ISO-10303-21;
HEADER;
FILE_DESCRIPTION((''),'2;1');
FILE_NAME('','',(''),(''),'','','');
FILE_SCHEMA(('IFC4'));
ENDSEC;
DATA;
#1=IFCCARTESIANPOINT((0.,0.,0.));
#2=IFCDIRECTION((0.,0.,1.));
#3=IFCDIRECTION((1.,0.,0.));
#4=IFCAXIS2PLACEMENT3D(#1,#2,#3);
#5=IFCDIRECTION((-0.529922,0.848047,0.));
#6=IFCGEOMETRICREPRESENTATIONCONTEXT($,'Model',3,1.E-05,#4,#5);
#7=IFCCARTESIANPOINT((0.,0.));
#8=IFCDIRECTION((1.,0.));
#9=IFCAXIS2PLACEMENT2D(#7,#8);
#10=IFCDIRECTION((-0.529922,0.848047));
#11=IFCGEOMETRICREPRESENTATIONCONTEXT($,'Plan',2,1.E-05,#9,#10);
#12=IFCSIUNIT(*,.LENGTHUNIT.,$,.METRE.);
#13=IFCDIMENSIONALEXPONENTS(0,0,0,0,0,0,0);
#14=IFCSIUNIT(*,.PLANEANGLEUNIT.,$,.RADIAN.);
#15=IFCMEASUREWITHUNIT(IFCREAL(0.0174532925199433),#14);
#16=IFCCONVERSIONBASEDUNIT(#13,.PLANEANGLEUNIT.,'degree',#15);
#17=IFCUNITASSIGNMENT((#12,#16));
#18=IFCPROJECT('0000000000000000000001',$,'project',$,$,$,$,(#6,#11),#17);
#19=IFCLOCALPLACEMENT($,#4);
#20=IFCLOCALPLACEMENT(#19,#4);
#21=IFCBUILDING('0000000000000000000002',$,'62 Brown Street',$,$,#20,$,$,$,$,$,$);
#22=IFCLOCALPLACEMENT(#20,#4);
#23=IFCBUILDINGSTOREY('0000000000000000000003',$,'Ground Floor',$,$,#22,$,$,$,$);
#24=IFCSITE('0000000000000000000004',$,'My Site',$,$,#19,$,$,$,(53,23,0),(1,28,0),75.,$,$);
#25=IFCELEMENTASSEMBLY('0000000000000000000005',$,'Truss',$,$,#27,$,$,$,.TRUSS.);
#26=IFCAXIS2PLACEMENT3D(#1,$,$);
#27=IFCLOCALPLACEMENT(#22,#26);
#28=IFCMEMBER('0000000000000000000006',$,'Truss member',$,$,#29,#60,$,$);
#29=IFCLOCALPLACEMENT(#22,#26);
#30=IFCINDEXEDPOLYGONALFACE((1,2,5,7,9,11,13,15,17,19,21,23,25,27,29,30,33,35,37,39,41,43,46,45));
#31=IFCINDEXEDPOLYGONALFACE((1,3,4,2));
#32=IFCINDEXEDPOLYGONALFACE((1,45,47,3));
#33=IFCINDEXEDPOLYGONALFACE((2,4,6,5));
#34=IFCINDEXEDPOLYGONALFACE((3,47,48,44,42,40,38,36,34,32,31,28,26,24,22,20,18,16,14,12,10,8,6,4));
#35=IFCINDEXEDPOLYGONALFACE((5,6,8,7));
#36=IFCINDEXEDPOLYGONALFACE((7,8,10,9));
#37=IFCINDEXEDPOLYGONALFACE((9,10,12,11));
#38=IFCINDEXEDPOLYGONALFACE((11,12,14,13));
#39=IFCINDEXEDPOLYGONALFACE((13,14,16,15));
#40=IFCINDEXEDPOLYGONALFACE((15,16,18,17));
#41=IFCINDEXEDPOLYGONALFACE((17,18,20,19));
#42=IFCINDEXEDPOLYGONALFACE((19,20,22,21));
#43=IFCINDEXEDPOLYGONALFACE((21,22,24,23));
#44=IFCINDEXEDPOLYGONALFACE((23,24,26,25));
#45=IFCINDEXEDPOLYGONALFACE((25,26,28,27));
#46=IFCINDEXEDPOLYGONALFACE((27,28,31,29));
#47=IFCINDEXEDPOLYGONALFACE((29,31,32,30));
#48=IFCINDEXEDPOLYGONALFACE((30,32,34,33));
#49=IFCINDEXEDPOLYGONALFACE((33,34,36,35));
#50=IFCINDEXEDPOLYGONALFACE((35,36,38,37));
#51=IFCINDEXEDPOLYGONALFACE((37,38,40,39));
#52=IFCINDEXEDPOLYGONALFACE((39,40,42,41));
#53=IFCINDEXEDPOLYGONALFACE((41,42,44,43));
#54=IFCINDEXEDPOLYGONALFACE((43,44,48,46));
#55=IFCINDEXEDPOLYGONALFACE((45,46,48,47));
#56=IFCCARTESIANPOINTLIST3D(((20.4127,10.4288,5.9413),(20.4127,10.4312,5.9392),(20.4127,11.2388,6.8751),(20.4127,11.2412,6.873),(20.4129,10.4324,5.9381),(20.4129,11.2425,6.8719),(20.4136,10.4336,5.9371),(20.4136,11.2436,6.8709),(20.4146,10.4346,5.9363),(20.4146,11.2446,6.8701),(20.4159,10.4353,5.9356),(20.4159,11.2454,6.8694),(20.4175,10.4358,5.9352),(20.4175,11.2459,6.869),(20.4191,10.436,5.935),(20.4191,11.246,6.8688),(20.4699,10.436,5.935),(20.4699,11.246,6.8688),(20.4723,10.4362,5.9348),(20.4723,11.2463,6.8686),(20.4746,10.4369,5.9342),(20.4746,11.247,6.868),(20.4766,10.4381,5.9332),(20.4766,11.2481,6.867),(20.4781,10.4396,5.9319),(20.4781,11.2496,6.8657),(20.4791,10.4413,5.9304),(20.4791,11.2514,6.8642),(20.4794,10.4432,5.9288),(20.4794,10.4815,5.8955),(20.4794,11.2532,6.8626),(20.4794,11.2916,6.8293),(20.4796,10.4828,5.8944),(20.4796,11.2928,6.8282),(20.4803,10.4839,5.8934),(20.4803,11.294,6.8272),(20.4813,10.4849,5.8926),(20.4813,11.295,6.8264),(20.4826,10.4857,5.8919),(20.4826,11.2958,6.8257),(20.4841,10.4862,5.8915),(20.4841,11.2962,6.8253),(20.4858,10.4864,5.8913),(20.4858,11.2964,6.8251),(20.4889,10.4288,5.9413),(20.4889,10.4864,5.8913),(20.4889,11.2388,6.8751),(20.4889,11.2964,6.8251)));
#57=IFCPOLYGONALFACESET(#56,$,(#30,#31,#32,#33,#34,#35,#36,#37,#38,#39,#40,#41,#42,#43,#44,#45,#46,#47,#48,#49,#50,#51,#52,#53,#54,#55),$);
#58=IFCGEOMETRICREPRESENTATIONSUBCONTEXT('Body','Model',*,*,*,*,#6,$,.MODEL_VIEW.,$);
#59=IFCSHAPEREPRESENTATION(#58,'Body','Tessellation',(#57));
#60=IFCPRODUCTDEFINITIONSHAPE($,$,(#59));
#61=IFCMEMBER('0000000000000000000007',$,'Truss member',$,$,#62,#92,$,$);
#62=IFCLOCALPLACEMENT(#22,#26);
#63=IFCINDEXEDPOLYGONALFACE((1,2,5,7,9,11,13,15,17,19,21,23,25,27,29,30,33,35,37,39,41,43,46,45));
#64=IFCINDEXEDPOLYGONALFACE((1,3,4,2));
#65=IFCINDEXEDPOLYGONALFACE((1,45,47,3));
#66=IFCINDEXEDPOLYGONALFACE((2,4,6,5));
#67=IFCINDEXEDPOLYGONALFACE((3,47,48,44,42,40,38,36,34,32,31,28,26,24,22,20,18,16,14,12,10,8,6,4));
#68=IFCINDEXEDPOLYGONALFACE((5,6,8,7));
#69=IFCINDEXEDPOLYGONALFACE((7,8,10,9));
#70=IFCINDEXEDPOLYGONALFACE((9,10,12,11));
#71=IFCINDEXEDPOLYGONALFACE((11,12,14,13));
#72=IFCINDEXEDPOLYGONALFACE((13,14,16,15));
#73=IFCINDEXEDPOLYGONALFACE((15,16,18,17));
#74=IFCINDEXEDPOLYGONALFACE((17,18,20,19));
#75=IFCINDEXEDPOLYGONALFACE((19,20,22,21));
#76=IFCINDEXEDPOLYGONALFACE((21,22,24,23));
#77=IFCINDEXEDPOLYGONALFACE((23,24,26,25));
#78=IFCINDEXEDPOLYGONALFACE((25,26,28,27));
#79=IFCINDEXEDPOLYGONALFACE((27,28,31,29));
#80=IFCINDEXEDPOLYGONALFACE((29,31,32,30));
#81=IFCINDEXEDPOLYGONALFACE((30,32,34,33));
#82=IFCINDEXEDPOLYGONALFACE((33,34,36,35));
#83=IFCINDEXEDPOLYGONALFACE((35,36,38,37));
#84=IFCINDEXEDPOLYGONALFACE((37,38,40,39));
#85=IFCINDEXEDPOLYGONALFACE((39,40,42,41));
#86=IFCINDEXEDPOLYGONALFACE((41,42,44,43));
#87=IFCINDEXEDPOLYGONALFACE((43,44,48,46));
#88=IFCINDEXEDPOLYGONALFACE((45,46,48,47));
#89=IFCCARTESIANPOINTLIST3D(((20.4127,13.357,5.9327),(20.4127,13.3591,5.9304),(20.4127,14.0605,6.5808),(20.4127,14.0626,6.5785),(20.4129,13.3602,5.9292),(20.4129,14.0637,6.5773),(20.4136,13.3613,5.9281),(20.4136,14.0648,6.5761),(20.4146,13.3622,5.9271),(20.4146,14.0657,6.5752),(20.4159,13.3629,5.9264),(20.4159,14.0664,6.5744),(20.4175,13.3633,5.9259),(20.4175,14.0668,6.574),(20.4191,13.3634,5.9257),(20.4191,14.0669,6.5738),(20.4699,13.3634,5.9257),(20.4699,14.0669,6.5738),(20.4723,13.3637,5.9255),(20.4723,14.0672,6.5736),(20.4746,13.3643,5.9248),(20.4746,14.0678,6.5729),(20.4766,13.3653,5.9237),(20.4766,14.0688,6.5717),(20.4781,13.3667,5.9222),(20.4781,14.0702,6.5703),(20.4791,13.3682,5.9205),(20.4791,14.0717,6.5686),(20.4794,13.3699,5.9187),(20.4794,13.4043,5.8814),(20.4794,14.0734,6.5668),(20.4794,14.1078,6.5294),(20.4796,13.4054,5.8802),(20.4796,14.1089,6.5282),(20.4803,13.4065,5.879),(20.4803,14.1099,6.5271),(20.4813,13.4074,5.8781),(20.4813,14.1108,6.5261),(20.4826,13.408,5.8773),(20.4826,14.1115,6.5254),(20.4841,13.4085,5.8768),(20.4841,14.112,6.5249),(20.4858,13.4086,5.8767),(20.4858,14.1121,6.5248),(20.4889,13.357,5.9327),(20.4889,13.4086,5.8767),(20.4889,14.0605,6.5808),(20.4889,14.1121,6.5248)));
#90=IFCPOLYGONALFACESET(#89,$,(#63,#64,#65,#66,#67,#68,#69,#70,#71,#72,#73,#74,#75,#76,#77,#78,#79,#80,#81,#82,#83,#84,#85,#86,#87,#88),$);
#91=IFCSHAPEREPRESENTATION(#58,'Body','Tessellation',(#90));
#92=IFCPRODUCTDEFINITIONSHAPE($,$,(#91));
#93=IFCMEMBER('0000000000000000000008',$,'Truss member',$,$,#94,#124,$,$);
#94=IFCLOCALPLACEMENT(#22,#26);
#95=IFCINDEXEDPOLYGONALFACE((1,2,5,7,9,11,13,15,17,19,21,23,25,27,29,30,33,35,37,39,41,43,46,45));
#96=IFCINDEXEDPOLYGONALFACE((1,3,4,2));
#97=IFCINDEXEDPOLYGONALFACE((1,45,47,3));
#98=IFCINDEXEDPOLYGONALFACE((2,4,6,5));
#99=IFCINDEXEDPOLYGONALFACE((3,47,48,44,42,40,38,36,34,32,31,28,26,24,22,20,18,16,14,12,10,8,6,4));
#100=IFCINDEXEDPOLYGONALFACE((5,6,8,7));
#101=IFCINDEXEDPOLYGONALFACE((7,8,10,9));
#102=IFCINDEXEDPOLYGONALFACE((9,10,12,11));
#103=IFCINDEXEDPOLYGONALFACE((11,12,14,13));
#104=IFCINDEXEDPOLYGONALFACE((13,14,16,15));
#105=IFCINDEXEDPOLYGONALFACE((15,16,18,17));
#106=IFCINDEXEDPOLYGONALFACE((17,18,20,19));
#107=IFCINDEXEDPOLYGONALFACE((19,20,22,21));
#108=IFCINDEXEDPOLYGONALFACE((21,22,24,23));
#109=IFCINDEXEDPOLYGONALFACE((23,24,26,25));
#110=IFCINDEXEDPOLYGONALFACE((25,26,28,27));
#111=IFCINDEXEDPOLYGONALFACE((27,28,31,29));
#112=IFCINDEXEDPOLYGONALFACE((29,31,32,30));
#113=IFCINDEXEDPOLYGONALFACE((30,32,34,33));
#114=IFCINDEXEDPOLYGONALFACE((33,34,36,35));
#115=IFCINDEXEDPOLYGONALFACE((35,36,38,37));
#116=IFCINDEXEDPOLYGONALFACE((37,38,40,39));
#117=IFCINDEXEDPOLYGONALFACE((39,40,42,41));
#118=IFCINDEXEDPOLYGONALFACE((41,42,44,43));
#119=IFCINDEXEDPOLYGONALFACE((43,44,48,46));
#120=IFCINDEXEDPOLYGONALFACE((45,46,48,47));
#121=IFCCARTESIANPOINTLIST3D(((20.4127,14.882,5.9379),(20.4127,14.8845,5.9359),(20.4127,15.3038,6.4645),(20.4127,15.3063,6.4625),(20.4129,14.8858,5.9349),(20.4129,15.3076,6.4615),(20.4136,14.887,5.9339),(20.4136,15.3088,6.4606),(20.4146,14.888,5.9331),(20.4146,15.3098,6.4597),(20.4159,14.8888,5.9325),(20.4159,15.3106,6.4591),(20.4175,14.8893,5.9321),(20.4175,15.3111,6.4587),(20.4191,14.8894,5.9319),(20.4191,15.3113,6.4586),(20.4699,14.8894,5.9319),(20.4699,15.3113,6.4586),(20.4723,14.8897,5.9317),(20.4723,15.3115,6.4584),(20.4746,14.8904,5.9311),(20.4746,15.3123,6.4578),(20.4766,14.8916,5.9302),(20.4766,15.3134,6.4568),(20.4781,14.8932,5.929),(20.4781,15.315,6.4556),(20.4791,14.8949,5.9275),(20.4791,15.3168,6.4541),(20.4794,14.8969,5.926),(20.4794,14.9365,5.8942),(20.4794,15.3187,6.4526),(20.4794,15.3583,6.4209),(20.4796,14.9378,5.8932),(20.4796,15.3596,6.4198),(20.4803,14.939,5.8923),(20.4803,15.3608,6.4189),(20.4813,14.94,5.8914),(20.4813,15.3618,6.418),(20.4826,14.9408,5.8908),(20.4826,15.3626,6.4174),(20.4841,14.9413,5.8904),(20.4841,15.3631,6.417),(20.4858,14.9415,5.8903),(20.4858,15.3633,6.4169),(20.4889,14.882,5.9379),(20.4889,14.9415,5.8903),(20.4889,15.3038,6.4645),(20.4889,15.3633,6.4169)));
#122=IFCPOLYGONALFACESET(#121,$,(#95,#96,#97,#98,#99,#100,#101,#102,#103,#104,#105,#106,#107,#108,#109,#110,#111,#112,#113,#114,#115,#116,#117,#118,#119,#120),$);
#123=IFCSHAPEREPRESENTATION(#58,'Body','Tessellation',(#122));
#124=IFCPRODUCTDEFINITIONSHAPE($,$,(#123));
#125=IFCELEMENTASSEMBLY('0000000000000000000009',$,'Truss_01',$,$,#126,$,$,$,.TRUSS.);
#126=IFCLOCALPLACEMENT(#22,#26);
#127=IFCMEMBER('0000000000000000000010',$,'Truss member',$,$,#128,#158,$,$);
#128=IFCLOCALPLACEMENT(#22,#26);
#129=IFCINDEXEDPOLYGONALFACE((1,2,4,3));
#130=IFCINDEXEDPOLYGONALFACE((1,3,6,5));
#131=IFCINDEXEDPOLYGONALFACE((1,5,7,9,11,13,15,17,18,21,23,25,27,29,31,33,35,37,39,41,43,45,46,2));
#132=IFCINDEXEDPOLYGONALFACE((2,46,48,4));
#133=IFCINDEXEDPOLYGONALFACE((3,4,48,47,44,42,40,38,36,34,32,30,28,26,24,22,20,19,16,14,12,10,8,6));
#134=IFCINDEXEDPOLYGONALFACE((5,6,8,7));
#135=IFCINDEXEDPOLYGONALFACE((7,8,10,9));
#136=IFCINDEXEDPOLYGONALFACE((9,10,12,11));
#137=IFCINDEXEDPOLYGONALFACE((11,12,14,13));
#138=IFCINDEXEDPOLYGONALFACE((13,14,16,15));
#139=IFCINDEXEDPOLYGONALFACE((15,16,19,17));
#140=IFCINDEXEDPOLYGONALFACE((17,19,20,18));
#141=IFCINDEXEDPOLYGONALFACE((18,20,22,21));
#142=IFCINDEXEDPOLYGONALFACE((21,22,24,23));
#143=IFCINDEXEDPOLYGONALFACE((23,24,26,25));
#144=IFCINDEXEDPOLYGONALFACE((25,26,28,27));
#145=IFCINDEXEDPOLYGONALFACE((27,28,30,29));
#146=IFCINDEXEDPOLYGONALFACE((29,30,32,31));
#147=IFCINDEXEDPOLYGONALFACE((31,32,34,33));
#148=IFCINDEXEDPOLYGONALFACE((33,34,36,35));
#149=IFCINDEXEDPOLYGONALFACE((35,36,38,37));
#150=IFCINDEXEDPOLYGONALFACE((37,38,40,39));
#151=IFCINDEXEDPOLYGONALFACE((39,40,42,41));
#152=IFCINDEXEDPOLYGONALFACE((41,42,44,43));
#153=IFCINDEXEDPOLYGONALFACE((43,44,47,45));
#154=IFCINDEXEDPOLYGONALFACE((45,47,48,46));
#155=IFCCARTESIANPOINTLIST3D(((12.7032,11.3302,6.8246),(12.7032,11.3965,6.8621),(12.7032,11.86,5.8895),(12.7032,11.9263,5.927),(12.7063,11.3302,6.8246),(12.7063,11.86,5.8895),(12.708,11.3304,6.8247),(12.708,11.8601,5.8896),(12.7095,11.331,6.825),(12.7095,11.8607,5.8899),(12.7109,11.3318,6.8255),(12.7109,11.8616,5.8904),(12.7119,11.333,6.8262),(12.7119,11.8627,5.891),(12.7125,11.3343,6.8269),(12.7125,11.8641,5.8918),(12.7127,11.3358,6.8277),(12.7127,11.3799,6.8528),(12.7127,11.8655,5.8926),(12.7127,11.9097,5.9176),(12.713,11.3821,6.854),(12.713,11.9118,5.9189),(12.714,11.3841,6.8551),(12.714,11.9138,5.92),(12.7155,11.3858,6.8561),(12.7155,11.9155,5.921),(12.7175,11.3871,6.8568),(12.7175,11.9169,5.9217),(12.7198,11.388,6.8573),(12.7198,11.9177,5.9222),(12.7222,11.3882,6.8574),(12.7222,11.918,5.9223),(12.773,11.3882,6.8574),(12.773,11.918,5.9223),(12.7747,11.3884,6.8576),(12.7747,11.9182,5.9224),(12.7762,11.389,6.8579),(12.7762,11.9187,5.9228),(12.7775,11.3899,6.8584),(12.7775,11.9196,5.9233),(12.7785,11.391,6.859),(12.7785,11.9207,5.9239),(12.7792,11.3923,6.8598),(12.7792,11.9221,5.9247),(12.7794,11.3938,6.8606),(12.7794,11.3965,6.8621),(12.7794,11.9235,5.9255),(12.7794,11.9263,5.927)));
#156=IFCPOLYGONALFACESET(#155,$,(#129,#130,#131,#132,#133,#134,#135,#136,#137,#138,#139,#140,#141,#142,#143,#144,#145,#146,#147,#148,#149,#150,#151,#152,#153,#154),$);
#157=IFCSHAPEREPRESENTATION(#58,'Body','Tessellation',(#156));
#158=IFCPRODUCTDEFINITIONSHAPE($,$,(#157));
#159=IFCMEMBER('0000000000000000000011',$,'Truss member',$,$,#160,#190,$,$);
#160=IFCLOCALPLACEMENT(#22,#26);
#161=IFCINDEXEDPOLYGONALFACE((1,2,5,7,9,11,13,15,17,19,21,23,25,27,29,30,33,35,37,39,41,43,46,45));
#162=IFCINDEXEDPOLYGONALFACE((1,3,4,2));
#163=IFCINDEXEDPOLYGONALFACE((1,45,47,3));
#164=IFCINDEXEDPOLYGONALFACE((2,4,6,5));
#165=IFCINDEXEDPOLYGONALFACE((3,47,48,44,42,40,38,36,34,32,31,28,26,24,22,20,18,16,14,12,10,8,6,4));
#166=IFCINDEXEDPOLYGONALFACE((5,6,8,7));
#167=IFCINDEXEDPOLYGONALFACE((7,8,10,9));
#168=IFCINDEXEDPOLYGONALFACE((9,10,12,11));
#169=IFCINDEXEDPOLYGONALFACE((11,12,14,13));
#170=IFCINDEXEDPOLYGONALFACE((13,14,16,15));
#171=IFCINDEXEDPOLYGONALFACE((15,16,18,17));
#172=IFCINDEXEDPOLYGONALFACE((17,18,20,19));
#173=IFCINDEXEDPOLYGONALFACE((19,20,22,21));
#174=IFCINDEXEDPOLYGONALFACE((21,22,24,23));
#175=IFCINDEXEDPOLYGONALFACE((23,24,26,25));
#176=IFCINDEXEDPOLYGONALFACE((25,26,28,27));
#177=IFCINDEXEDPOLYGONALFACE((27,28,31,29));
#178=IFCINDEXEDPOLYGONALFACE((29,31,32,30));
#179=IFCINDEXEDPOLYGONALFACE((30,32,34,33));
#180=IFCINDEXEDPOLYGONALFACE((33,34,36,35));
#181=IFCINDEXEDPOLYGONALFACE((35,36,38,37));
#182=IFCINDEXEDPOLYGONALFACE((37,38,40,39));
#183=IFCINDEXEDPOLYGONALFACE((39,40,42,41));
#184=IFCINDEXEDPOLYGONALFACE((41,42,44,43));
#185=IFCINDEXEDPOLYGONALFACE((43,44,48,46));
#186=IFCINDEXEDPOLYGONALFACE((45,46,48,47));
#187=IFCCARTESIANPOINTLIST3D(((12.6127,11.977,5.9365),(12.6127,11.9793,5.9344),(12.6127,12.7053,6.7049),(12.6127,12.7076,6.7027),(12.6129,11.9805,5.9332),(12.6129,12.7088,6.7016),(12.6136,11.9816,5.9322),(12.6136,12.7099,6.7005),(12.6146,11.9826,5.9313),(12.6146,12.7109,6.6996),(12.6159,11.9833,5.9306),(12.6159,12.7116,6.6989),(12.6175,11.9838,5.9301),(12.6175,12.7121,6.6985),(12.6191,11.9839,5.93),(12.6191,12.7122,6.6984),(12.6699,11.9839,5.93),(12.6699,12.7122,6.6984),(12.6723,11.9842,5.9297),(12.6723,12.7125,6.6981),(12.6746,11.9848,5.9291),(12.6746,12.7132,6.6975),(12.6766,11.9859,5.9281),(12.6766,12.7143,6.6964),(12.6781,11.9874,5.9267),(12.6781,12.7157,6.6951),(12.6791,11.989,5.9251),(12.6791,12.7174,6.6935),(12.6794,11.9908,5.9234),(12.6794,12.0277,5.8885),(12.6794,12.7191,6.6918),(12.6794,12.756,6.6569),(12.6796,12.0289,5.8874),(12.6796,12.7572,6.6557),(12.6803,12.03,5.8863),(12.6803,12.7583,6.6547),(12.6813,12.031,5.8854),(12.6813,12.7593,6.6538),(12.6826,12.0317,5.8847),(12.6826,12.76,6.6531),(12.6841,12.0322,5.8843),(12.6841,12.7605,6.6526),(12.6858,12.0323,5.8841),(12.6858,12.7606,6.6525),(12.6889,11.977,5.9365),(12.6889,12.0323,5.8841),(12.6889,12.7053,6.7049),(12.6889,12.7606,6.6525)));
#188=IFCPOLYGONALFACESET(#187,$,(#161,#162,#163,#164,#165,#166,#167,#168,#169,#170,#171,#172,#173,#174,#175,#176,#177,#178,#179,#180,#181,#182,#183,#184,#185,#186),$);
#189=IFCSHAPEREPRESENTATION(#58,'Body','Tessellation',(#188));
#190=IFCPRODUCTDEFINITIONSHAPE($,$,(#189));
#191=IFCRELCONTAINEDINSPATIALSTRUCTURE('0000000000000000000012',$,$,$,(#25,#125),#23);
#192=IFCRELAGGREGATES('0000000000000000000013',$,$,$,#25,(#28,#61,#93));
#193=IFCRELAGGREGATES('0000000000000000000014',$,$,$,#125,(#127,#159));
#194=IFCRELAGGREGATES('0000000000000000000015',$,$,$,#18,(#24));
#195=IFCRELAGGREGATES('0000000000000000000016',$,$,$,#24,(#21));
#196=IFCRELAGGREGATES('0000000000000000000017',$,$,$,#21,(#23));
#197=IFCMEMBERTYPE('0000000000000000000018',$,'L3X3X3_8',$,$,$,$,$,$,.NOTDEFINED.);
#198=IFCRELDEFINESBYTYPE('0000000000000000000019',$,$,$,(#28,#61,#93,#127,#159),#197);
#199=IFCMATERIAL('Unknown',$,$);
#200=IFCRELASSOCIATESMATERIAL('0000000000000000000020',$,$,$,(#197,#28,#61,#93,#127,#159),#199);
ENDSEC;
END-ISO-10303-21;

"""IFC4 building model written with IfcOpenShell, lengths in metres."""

from ifc_helpers import new_model, entity, si_unit, converted_unit, direction, frame, origin_with_axes, origin_2d_with_axis, place, context, subcontext, project, spatial, l_section, extrude, material, material_profile, profile_set, profile_usage, type_object, element, aggregate, save


model = new_model("IFC4")

# Units and contexts
model_context = context("Model", 3, precision=1e-05, world=origin_with_axes(), true_north=direction((-0.529922, 0.848047, 0.0)))
plan_context = context("Plan", 2, precision=1e-05, world=origin_2d_with_axis(), true_north=direction((-0.529922, 0.848047)))
body_context = subcontext(model_context, "Body", "Model", "MODEL_VIEW")
ifc_project = project(units=[si_unit("LENGTHUNIT", "METRE"), converted_unit("PLANEANGLEUNIT", "degree", entity("IfcReal", 0.0174532925199433), si_unit("PLANEANGLEUNIT", "RADIAN"), dimensions=[0, 0, 0, 0, 0, 0, 0])], contexts=[model_context, plan_context])

# Site, building, storey
site_placement = place(None, origin_with_axes())
site = spatial("IfcSite", under=ifc_project, at=site_placement, Name="My Site", RefLatitude=(53, 23, 0), RefLongitude=(1, 28, 0), RefElevation=75.0)
building_placement = place(site_placement, origin_with_axes())
building = spatial("IfcBuilding", under=site, at=building_placement, Name="62 Brown Street")
storey_placement = place(building_placement, origin_with_axes())
storey = spatial("IfcBuildingStorey", under=building, at=storey_placement, Name="Ground Floor")

# Element assemblies, members
assembly_1_placement = place(storey_placement, frame((20.5032, 10.4288, 6.9738), z_axis=(0.0, 0.0, 1.0), x_axis=(1.0, 0.0, 0.0)))
assembly_1 = element("IfcElementAssembly", 1, at=assembly_1_placement, inside=storey, Name="Truss", PredefinedType="TRUSS")
ifc_material_1 = material(Name="Unknown")
ifc_material_profile_1 = material_profile(ifc_material_1, l_section(Depth=0.0762, Width=0.0762, Thickness=0.0095, FilletRadius=0.0095, EdgeRadius=0.0064))
ifc_profile_set_1 = profile_set([ifc_material_profile_1])
ifc_profile_usage_1 = profile_usage(ifc_profile_set_1, cardinal=5)
member_type_1 = type_object("IfcMemberType", Name="L3X3X3_8", PredefinedType="NOTDEFINED", material=ifc_profile_set_1)
member_1_placement = place(assembly_1_placement, frame((-0.0524, 0.8388, -0.1236), z_axis=(0.000001, -0.655276, -0.755389), x_axis=(-1.0, -0.000001, 0.0)))
member_1 = element("IfcMember", 2, at=member_1_placement, type_object=member_type_1, material=ifc_profile_usage_1, Name="Truss member", context=body_context, shape_type="SweptSolid", body=[
    extrude(l_section(Depth=0.0762, Width=0.0762, Thickness=0.0095, FilletRadius=0.0095, EdgeRadius=0.0064), origin_with_axes(), (0.0, 0.0, 1.0), 1.2362),
])
ifc_profile_usage_2 = profile_usage(ifc_profile_set_1, cardinal=5)
member_2_placement = place(assembly_1_placement, frame((-0.0524, 3.6575, -0.421), z_axis=(0.000001, -0.735484, -0.677542), x_axis=(-1.0, -0.000001, 0.0)))
member_2 = element("IfcMember", 3, at=member_2_placement, type_object=member_type_1, material=ifc_profile_usage_2, Name="Truss member", context=body_context, shape_type="SweptSolid", body=[
    extrude(l_section(Depth=0.0762, Width=0.0762, Thickness=0.0095, FilletRadius=0.0095, EdgeRadius=0.0064), origin_with_axes(), (0.0, 0.0, 1.0), 0.9565),
])
ifc_profile_usage_3 = profile_usage(ifc_profile_set_1, cardinal=5)
member_3_placement = place(assembly_1_placement, frame((-0.0524, 4.9048, -0.5331), z_axis=(0.000001, -0.625169, -0.780489), x_axis=(-1.0, -0.000001, 0.0)))
member_3 = element("IfcMember", 4, at=member_3_placement, type_object=member_type_1, material=ifc_profile_usage_3, Name="Truss member", context=body_context, shape_type="SweptSolid", body=[
    extrude(l_section(Depth=0.0762, Width=0.0762, Thickness=0.0095, FilletRadius=0.0095, EdgeRadius=0.0064), origin_with_axes(), (0.0, 0.0, 1.0), 0.6747),
])
aggregate(assembly_1, [member_1, member_2, member_3])
assembly_2_placement = place(storey_placement, frame((12.7032, 10.4288, 6.9738), z_axis=(0.0, 0.0, 1.0), x_axis=(1.0, 0.0, 0.0)))
assembly_2 = element("IfcElementAssembly", 5, at=assembly_2_placement, inside=storey, Name="Truss_01", PredefinedType="TRUSS")
ifc_profile_usage_4 = profile_usage(ifc_profile_set_1, cardinal=5)
member_4_placement = place(assembly_2_placement, frame((0.0381, 0.9346, -0.1304), z_axis=(0.0, 0.492899, -0.870086), x_axis=(1.0, 0.0, 0.0)))
member_4 = element("IfcMember", 6, at=member_4_placement, type_object=member_type_1, material=ifc_profile_usage_4, Name="Truss member", context=body_context, shape_type="SweptSolid", body=[
    extrude(l_section(Depth=0.0762, Width=0.0762, Thickness=0.0095, FilletRadius=0.0095, EdgeRadius=0.0064), origin_with_axes(), (0.0, 0.0, 1.0), 1.0747),
])
ifc_profile_usage_5 = profile_usage(ifc_profile_set_1, cardinal=5)
member_5_placement = place(assembly_2_placement, frame((-0.0524, 2.3042, -0.2951), z_axis=(0.000001, -0.687927, -0.72578), x_axis=(-1.0, 0.0, 0.0)))
member_5 = element("IfcMember", 7, at=member_5_placement, type_object=member_type_1, material=ifc_profile_usage_5, Name="Truss member", context=body_context, shape_type="SweptSolid", body=[
    extrude(l_section(Depth=0.0762, Width=0.0762, Thickness=0.0095, FilletRadius=0.0095, EdgeRadius=0.0064), origin_with_axes(), (0.0, 0.0, 1.0), 1.0587),
])

aggregate(assembly_2, [member_4, member_5])

save(model, "model.ifc")
